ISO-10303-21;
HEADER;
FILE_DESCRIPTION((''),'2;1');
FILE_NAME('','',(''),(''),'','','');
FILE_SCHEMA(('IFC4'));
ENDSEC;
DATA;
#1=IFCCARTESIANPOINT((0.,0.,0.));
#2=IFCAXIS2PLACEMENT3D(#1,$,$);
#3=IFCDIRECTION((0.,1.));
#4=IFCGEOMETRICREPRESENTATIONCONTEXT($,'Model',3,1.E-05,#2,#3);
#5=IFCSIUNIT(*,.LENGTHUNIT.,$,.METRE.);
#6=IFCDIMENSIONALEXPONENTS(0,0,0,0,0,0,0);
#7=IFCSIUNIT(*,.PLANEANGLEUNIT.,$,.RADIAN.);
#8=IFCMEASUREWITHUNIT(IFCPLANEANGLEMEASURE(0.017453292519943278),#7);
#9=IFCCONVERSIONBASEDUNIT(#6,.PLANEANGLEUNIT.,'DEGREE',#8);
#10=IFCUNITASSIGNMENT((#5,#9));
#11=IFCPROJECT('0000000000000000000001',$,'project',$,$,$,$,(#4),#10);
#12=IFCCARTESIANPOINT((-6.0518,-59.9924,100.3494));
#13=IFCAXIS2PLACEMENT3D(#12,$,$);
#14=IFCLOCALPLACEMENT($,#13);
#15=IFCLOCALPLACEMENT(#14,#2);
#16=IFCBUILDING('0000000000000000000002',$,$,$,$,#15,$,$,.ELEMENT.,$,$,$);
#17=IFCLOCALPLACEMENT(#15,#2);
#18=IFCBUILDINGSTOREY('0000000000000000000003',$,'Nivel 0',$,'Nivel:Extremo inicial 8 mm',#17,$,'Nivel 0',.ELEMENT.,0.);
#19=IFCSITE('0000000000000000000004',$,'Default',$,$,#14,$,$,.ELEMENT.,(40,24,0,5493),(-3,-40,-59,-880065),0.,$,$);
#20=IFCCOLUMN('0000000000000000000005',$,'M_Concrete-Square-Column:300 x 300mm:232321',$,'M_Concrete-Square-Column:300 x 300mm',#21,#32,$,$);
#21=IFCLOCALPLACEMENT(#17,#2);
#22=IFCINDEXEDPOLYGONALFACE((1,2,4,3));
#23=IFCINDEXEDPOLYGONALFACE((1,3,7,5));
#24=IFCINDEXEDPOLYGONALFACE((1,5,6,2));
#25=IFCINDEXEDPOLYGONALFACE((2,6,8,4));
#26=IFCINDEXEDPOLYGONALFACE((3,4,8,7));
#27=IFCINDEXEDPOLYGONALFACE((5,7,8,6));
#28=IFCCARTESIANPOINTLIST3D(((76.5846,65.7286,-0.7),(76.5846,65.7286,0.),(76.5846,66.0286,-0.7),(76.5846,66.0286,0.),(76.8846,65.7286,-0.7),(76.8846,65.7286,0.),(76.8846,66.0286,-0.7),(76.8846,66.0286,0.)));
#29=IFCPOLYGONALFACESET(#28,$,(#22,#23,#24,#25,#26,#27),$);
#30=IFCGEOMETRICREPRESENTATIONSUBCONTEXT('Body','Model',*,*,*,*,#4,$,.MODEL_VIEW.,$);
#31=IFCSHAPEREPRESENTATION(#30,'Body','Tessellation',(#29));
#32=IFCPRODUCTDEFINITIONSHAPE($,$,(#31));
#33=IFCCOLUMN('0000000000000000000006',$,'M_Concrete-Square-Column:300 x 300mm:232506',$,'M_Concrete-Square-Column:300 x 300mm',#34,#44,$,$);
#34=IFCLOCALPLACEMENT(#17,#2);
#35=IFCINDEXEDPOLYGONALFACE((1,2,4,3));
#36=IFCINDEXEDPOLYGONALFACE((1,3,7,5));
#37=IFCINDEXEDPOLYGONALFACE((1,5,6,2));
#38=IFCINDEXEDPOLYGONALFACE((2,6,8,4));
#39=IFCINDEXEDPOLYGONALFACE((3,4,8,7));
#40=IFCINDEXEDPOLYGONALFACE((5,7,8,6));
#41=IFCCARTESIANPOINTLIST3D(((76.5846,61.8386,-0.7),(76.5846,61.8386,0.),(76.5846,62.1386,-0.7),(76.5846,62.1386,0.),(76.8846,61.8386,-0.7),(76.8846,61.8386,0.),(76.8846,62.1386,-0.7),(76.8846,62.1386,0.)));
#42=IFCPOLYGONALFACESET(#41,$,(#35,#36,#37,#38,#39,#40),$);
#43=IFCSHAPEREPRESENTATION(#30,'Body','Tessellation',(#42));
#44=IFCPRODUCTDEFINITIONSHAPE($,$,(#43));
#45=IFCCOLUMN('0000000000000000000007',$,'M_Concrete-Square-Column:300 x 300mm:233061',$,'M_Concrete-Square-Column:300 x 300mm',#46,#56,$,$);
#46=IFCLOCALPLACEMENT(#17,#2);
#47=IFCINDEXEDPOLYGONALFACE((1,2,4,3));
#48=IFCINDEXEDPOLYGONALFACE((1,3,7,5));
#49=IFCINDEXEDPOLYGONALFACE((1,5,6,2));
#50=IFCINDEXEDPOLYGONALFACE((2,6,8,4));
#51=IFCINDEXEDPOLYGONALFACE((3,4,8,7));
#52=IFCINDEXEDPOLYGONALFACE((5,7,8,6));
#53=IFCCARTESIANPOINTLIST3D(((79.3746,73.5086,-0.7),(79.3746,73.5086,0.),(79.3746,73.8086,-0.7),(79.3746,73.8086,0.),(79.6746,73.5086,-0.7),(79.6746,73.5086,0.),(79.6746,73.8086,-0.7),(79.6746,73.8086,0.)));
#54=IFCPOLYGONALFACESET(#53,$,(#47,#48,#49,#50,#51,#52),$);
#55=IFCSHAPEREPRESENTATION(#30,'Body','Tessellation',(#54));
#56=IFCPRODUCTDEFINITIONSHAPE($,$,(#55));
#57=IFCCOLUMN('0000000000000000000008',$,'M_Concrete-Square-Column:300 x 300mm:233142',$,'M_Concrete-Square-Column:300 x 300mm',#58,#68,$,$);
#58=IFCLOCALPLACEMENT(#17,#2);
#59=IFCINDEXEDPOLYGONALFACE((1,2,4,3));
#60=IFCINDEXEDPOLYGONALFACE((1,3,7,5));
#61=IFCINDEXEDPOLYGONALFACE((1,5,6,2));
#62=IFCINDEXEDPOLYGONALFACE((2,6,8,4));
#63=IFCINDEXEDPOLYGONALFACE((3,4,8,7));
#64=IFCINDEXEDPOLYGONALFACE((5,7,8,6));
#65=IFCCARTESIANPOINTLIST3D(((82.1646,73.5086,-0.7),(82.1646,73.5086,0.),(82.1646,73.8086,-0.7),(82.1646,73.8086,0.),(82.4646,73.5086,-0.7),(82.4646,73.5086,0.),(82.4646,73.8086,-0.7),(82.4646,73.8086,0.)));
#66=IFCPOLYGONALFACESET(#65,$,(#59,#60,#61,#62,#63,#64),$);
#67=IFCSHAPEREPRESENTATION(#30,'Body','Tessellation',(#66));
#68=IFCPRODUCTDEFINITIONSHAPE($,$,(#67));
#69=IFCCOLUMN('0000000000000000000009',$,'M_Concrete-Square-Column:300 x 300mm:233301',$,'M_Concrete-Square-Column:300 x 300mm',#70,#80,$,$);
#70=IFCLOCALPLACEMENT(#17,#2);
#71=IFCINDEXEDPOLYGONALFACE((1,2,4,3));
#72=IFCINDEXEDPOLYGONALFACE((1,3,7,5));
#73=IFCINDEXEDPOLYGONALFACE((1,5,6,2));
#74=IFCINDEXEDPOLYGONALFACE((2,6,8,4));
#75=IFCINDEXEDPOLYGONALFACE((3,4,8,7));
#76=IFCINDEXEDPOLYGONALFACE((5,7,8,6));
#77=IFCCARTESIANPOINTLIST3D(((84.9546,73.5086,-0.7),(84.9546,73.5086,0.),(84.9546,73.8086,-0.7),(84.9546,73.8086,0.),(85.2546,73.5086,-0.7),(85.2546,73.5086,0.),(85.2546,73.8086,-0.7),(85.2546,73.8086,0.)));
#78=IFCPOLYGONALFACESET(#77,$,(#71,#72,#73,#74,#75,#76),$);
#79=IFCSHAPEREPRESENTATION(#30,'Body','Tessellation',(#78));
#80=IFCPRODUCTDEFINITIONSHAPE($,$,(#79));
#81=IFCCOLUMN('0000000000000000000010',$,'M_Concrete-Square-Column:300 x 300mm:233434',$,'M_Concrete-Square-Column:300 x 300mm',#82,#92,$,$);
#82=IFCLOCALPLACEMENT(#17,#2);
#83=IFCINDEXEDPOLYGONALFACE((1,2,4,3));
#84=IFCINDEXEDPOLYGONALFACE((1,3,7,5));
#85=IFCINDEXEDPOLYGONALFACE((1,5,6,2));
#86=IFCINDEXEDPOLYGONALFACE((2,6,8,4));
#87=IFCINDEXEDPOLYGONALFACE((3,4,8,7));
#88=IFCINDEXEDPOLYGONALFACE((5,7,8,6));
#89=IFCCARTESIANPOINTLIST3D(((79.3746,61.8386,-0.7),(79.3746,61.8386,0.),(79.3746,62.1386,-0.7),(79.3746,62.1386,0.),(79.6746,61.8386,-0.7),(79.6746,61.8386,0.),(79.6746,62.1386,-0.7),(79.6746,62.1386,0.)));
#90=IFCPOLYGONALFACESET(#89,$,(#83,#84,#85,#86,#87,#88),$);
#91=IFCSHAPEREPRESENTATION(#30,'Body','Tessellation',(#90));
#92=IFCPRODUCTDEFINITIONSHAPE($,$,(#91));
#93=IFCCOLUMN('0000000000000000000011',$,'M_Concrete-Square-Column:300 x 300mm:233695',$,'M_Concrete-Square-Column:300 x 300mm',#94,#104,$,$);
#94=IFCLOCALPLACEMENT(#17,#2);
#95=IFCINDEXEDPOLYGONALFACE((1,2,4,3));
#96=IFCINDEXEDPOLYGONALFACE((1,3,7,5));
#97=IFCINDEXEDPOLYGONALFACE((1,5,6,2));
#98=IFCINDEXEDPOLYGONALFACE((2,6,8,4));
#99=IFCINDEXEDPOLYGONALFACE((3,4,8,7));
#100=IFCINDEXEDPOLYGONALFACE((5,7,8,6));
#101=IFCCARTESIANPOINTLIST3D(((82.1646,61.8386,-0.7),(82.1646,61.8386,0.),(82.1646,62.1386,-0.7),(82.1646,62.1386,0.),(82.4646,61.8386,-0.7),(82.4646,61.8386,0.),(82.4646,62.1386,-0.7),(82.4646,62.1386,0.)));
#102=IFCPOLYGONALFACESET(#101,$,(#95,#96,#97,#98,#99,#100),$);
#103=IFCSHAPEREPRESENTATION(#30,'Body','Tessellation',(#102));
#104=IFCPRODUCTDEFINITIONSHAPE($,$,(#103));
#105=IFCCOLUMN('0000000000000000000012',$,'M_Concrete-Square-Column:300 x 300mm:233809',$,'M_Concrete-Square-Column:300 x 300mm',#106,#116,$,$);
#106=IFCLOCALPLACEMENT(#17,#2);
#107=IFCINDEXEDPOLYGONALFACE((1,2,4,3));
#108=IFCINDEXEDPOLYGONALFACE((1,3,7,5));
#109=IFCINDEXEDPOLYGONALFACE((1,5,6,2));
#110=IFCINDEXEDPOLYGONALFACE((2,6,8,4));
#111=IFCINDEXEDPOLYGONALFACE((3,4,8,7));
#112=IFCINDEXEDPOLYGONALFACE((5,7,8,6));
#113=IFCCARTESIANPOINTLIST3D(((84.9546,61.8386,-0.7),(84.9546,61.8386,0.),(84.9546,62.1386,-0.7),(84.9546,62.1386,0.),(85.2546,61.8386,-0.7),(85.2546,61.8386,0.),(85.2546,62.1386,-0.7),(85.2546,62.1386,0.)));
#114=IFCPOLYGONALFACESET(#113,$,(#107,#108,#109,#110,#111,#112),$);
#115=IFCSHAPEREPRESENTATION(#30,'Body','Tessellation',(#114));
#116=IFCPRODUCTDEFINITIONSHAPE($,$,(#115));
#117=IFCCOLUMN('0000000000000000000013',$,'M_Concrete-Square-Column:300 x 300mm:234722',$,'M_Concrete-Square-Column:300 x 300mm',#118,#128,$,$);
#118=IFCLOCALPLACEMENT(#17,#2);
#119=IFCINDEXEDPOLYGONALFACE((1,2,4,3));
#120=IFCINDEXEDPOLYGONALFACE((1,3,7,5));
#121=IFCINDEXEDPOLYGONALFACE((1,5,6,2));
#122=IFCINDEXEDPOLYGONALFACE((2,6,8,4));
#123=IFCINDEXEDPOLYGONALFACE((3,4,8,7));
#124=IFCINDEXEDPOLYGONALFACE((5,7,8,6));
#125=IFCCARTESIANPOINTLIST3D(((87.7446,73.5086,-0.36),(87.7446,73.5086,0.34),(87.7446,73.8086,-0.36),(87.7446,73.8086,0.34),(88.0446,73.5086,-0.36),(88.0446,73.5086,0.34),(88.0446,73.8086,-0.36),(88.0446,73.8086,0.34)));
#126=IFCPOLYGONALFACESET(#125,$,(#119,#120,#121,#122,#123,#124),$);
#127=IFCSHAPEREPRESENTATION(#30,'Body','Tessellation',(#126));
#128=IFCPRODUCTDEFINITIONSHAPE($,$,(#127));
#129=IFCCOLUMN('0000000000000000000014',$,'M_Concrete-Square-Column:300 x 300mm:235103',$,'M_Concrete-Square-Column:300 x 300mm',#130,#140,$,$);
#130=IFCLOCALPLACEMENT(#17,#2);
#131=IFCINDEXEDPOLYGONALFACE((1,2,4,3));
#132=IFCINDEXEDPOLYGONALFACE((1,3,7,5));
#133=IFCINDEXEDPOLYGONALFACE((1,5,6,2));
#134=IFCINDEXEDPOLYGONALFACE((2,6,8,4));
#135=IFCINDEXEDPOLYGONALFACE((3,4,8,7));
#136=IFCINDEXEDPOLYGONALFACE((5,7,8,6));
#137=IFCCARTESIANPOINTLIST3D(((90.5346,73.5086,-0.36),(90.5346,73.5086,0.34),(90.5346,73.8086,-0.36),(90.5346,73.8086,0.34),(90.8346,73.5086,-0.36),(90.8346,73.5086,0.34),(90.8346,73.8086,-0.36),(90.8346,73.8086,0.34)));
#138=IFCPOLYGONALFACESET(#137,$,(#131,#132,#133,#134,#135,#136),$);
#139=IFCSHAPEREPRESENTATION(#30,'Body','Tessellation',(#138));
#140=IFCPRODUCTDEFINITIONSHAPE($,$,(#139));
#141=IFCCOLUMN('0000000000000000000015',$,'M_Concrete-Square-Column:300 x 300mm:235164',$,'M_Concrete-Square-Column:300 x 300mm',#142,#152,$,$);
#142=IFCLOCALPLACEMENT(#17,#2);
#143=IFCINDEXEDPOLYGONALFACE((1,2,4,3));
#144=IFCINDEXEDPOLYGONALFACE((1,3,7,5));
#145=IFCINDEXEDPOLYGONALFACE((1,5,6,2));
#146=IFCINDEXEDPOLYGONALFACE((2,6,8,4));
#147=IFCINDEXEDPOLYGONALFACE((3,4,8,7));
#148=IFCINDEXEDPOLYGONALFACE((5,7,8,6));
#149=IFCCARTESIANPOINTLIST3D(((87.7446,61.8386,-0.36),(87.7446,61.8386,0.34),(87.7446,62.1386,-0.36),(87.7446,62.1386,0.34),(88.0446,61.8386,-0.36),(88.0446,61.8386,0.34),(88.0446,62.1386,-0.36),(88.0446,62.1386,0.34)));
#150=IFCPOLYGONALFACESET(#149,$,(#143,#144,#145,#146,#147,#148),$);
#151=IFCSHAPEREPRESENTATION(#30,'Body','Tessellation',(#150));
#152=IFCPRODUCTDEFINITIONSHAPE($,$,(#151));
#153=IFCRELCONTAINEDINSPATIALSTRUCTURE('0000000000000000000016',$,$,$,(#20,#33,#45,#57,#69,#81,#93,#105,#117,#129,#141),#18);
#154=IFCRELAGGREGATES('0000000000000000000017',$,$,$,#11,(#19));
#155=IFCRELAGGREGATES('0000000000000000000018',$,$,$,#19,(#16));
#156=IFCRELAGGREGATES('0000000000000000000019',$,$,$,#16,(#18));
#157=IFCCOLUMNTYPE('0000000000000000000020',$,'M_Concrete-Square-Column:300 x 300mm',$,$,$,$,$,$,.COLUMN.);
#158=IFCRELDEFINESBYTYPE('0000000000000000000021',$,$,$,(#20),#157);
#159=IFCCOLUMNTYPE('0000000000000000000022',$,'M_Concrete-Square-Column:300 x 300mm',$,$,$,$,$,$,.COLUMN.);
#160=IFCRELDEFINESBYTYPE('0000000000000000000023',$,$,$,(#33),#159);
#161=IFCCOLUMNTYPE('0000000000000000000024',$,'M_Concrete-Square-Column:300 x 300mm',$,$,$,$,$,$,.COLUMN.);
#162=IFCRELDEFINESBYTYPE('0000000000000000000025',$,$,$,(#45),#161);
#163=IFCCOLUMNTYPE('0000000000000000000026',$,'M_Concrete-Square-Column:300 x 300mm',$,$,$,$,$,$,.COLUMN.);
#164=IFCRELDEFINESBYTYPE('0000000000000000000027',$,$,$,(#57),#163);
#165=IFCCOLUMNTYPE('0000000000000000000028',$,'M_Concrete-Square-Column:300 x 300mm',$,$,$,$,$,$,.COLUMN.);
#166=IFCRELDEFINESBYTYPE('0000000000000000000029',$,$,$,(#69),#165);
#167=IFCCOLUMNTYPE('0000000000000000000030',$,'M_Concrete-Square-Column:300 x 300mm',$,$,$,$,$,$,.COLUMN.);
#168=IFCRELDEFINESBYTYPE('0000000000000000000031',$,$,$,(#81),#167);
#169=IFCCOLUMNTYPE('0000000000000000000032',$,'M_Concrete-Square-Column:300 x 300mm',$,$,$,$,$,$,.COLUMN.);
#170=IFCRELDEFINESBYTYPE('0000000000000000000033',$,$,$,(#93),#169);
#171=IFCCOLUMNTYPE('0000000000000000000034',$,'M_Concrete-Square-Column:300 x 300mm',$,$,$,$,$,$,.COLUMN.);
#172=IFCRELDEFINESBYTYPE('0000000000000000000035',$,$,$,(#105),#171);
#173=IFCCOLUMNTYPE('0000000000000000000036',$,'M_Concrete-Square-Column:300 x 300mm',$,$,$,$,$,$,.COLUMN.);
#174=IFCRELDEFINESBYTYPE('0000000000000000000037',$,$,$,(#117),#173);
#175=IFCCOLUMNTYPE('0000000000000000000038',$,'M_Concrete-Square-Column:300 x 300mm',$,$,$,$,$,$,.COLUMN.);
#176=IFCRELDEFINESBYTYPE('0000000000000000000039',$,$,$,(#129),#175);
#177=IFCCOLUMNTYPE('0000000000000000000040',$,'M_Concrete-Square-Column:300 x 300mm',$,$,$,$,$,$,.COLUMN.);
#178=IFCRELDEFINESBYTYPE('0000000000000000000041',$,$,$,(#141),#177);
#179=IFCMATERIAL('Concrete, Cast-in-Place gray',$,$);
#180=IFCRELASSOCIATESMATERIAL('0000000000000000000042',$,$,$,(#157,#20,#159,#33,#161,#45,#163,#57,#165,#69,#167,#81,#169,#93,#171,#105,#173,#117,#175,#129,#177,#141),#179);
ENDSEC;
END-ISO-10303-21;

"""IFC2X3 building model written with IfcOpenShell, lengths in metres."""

from ifc_helpers import new_model, entity, si_unit, converted_unit, direction, frame, origin, origin_2d_with_axis, place, context, subcontext, project, spatial, rectangle, extrude, source, transform, mapped, material, type_object, type_shapes, element, save


model = new_model("IFC2X3")

# Units and contexts
model_context = context("Model", 3, precision=1e-05, world=origin(), true_north=direction((0.0, 1.0)))
body_context = subcontext(model_context, "Body", "Model", "MODEL_VIEW")
ifc_project = project(units=[si_unit("LENGTHUNIT", "METRE"), converted_unit("PLANEANGLEUNIT", "DEGREE", entity("IfcPlaneAngleMeasure", 0.017453292519943278), si_unit("PLANEANGLEUNIT", "RADIAN"), dimensions=[0, 0, 0, 0, 0, 0, 0])], contexts=[model_context])

# Site, building, storey
site_placement = place(None, frame((-6.0518, -59.9924, 100.3494)))
site = spatial("IfcSite", under=ifc_project, at=site_placement, Name="Default", CompositionType="ELEMENT", RefLatitude=(40, 24, 0, 5493), RefLongitude=(-3, -40, -59, -880065), RefElevation=0.0)
building_placement = place(site_placement, origin())
building = spatial("IfcBuilding", under=site, at=building_placement, CompositionType="ELEMENT")
storey_placement = place(building_placement, origin())
storey = spatial("IfcBuildingStorey", under=building, at=storey_placement, Name="Nivel 0", ObjectType="Nivel:Extremo inicial 8 mm", LongName="Nivel 0", CompositionType="ELEMENT", Elevation=0.0)

# Columns
ifc_material = material(Name="Concrete, Cast-in-Place gray")
column_type_1 = type_object("IfcColumnType", Name="M_Concrete-Square-Column:300 x 300mm", PredefinedType="COLUMN", material=ifc_material)
shared_shape_1 = source(origin(), body_context, "Body", "SweptSolid", [
    extrude(rectangle(XDim=0.3, YDim=0.3, at=origin_2d_with_axis()), frame((76.7346, 65.8786, -0.7), z_axis=(0.0, 0.0, 1.0), x_axis=(-1.0, 0.0, 0.0)), (0.0, 0.0, 1.0), 0.7),
])
type_shapes(column_type_1, [shared_shape_1])
column_1_placement = place(storey_placement, origin())
element("IfcColumn", 1, at=column_1_placement, inside=storey, type_object=column_type_1, material=ifc_material, Name="M_Concrete-Square-Column:300 x 300mm:232321", ObjectType="M_Concrete-Square-Column:300 x 300mm", context=body_context, shape_type="MappedRepresentation", body=[
    mapped(shared_shape_1, transform((0.0, 0.0, 0.0), scale=1.0)),
])
column_type_2 = type_object("IfcColumnType", Name="M_Concrete-Square-Column:300 x 300mm", PredefinedType="COLUMN", material=ifc_material)
shared_shape_2 = source(origin(), body_context, "Body", "SweptSolid", [
    extrude(rectangle(XDim=0.3, YDim=0.3, at=origin_2d_with_axis()), frame((76.7346, 61.9886, -0.7), z_axis=(0.0, 0.0, 1.0), x_axis=(-1.0, 0.0, 0.0)), (0.0, 0.0, 1.0), 0.7),
])
type_shapes(column_type_2, [shared_shape_2])
column_2_placement = place(storey_placement, origin())
element("IfcColumn", 2, at=column_2_placement, inside=storey, type_object=column_type_2, material=ifc_material, Name="M_Concrete-Square-Column:300 x 300mm:232506", ObjectType="M_Concrete-Square-Column:300 x 300mm", context=body_context, shape_type="MappedRepresentation", body=[
    mapped(shared_shape_2, transform((0.0, 0.0, 0.0), scale=1.0)),
])
column_type_3 = type_object("IfcColumnType", Name="M_Concrete-Square-Column:300 x 300mm", PredefinedType="COLUMN", material=ifc_material)
shared_shape_3 = source(origin(), body_context, "Body", "SweptSolid", [
    extrude(rectangle(XDim=0.3, YDim=0.3, at=origin_2d_with_axis()), frame((79.5246, 73.6586, -0.7), z_axis=(0.0, 0.0, 1.0), x_axis=(-1.0, 0.0, 0.0)), (0.0, 0.0, 1.0), 0.7),
])
type_shapes(column_type_3, [shared_shape_3])
column_3_placement = place(storey_placement, origin())
element("IfcColumn", 3, at=column_3_placement, inside=storey, type_object=column_type_3, material=ifc_material, Name="M_Concrete-Square-Column:300 x 300mm:233061", ObjectType="M_Concrete-Square-Column:300 x 300mm", context=body_context, shape_type="MappedRepresentation", body=[
    mapped(shared_shape_3, transform((0.0, 0.0, 0.0), scale=1.0)),
])
column_type_4 = type_object("IfcColumnType", Name="M_Concrete-Square-Column:300 x 300mm", PredefinedType="COLUMN", material=ifc_material)
shared_shape_4 = source(origin(), body_context, "Body", "SweptSolid", [
    extrude(rectangle(XDim=0.3, YDim=0.3, at=origin_2d_with_axis()), frame((82.3146, 73.6586, -0.7), z_axis=(0.0, 0.0, 1.0), x_axis=(-1.0, 0.0, 0.0)), (0.0, 0.0, 1.0), 0.7),
])
type_shapes(column_type_4, [shared_shape_4])
column_4_placement = place(storey_placement, origin())
element("IfcColumn", 4, at=column_4_placement, inside=storey, type_object=column_type_4, material=ifc_material, Name="M_Concrete-Square-Column:300 x 300mm:233142", ObjectType="M_Concrete-Square-Column:300 x 300mm", context=body_context, shape_type="MappedRepresentation", body=[
    mapped(shared_shape_4, transform((0.0, 0.0, 0.0), scale=1.0)),
])
column_type_5 = type_object("IfcColumnType", Name="M_Concrete-Square-Column:300 x 300mm", PredefinedType="COLUMN", material=ifc_material)
shared_shape_5 = source(origin(), body_context, "Body", "SweptSolid", [
    extrude(rectangle(XDim=0.3, YDim=0.3, at=origin_2d_with_axis()), frame((85.1046, 73.6586, -0.7), z_axis=(0.0, 0.0, 1.0), x_axis=(-1.0, 0.0, 0.0)), (0.0, 0.0, 1.0), 0.7),
])
type_shapes(column_type_5, [shared_shape_5])
column_5_placement = place(storey_placement, origin())
element("IfcColumn", 5, at=column_5_placement, inside=storey, type_object=column_type_5, material=ifc_material, Name="M_Concrete-Square-Column:300 x 300mm:233301", ObjectType="M_Concrete-Square-Column:300 x 300mm", context=body_context, shape_type="MappedRepresentation", body=[
    mapped(shared_shape_5, transform((0.0, 0.0, 0.0), scale=1.0)),
])
column_type_6 = type_object("IfcColumnType", Name="M_Concrete-Square-Column:300 x 300mm", PredefinedType="COLUMN", material=ifc_material)
shared_shape_6 = source(origin(), body_context, "Body", "SweptSolid", [
    extrude(rectangle(XDim=0.3, YDim=0.3, at=origin_2d_with_axis()), frame((79.5246, 61.9886, -0.7), z_axis=(0.0, 0.0, 1.0), x_axis=(-1.0, 0.0, 0.0)), (0.0, 0.0, 1.0), 0.7),
])
type_shapes(column_type_6, [shared_shape_6])
column_6_placement = place(storey_placement, origin())
element("IfcColumn", 6, at=column_6_placement, inside=storey, type_object=column_type_6, material=ifc_material, Name="M_Concrete-Square-Column:300 x 300mm:233434", ObjectType="M_Concrete-Square-Column:300 x 300mm", context=body_context, shape_type="MappedRepresentation", body=[
    mapped(shared_shape_6, transform((0.0, 0.0, 0.0), scale=1.0)),
])
column_type_7 = type_object("IfcColumnType", Name="M_Concrete-Square-Column:300 x 300mm", PredefinedType="COLUMN", material=ifc_material)
shared_shape_7 = source(origin(), body_context, "Body", "SweptSolid", [
    extrude(rectangle(XDim=0.3, YDim=0.3, at=origin_2d_with_axis()), frame((82.3146, 61.9886, -0.7), z_axis=(0.0, 0.0, 1.0), x_axis=(-1.0, 0.0, 0.0)), (0.0, 0.0, 1.0), 0.7),
])
type_shapes(column_type_7, [shared_shape_7])
column_7_placement = place(storey_placement, origin())
element("IfcColumn", 7, at=column_7_placement, inside=storey, type_object=column_type_7, material=ifc_material, Name="M_Concrete-Square-Column:300 x 300mm:233695", ObjectType="M_Concrete-Square-Column:300 x 300mm", context=body_context, shape_type="MappedRepresentation", body=[
    mapped(shared_shape_7, transform((0.0, 0.0, 0.0), scale=1.0)),
])
column_type_8 = type_object("IfcColumnType", Name="M_Concrete-Square-Column:300 x 300mm", PredefinedType="COLUMN", material=ifc_material)
shared_shape_8 = source(origin(), body_context, "Body", "SweptSolid", [
    extrude(rectangle(XDim=0.3, YDim=0.3, at=origin_2d_with_axis()), frame((85.1046, 61.9886, -0.7), z_axis=(0.0, 0.0, 1.0), x_axis=(-1.0, 0.0, 0.0)), (0.0, 0.0, 1.0), 0.7),
])
type_shapes(column_type_8, [shared_shape_8])
column_8_placement = place(storey_placement, origin())
element("IfcColumn", 8, at=column_8_placement, inside=storey, type_object=column_type_8, material=ifc_material, Name="M_Concrete-Square-Column:300 x 300mm:233809", ObjectType="M_Concrete-Square-Column:300 x 300mm", context=body_context, shape_type="MappedRepresentation", body=[
    mapped(shared_shape_8, transform((0.0, 0.0, 0.0), scale=1.0)),
])
column_type_9 = type_object("IfcColumnType", Name="M_Concrete-Square-Column:300 x 300mm", PredefinedType="COLUMN", material=ifc_material)
shared_shape_9 = source(origin(), body_context, "Body", "SweptSolid", [
    extrude(rectangle(XDim=0.3, YDim=0.3, at=origin_2d_with_axis()), frame((87.8946, 73.6586, -0.36), z_axis=(0.0, 0.0, 1.0), x_axis=(-1.0, 0.0, 0.0)), (0.0, 0.0, 1.0), 0.7),
])
type_shapes(column_type_9, [shared_shape_9])
column_9_placement = place(storey_placement, origin())
element("IfcColumn", 9, at=column_9_placement, inside=storey, type_object=column_type_9, material=ifc_material, Name="M_Concrete-Square-Column:300 x 300mm:234722", ObjectType="M_Concrete-Square-Column:300 x 300mm", context=body_context, shape_type="MappedRepresentation", body=[
    mapped(shared_shape_9, transform((0.0, 0.0, 0.0), scale=1.0)),
])
column_type_10 = type_object("IfcColumnType", Name="M_Concrete-Square-Column:300 x 300mm", PredefinedType="COLUMN", material=ifc_material)
shared_shape_10 = source(origin(), body_context, "Body", "SweptSolid", [
    extrude(rectangle(XDim=0.3, YDim=0.3, at=origin_2d_with_axis()), frame((90.6846, 73.6586, -0.36), z_axis=(0.0, 0.0, 1.0), x_axis=(-1.0, 0.0, 0.0)), (0.0, 0.0, 1.0), 0.7),
])
type_shapes(column_type_10, [shared_shape_10])
column_10_placement = place(storey_placement, origin())
element("IfcColumn", 10, at=column_10_placement, inside=storey, type_object=column_type_10, material=ifc_material, Name="M_Concrete-Square-Column:300 x 300mm:235103", ObjectType="M_Concrete-Square-Column:300 x 300mm", context=body_context, shape_type="MappedRepresentation", body=[
    mapped(shared_shape_10, transform((0.0, 0.0, 0.0), scale=1.0)),
])
column_type_11 = type_object("IfcColumnType", Name="M_Concrete-Square-Column:300 x 300mm", PredefinedType="COLUMN", material=ifc_material)
shared_shape_11 = source(origin(), body_context, "Body", "SweptSolid", [
    extrude(rectangle(XDim=0.3, YDim=0.3, at=origin_2d_with_axis()), frame((87.8946, 61.9886, -0.36), z_axis=(0.0, 0.0, 1.0), x_axis=(-1.0, 0.0, 0.0)), (0.0, 0.0, 1.0), 0.7),
])
type_shapes(column_type_11, [shared_shape_11])
column_11_placement = place(storey_placement, origin())
element("IfcColumn", 11, at=column_11_placement, inside=storey, type_object=column_type_11, material=ifc_material, Name="M_Concrete-Square-Column:300 x 300mm:235164", ObjectType="M_Concrete-Square-Column:300 x 300mm", context=body_context, shape_type="MappedRepresentation", body=[
    mapped(shared_shape_11, transform((0.0, 0.0, 0.0), scale=1.0)),
])

save(model, "model.ifc")
